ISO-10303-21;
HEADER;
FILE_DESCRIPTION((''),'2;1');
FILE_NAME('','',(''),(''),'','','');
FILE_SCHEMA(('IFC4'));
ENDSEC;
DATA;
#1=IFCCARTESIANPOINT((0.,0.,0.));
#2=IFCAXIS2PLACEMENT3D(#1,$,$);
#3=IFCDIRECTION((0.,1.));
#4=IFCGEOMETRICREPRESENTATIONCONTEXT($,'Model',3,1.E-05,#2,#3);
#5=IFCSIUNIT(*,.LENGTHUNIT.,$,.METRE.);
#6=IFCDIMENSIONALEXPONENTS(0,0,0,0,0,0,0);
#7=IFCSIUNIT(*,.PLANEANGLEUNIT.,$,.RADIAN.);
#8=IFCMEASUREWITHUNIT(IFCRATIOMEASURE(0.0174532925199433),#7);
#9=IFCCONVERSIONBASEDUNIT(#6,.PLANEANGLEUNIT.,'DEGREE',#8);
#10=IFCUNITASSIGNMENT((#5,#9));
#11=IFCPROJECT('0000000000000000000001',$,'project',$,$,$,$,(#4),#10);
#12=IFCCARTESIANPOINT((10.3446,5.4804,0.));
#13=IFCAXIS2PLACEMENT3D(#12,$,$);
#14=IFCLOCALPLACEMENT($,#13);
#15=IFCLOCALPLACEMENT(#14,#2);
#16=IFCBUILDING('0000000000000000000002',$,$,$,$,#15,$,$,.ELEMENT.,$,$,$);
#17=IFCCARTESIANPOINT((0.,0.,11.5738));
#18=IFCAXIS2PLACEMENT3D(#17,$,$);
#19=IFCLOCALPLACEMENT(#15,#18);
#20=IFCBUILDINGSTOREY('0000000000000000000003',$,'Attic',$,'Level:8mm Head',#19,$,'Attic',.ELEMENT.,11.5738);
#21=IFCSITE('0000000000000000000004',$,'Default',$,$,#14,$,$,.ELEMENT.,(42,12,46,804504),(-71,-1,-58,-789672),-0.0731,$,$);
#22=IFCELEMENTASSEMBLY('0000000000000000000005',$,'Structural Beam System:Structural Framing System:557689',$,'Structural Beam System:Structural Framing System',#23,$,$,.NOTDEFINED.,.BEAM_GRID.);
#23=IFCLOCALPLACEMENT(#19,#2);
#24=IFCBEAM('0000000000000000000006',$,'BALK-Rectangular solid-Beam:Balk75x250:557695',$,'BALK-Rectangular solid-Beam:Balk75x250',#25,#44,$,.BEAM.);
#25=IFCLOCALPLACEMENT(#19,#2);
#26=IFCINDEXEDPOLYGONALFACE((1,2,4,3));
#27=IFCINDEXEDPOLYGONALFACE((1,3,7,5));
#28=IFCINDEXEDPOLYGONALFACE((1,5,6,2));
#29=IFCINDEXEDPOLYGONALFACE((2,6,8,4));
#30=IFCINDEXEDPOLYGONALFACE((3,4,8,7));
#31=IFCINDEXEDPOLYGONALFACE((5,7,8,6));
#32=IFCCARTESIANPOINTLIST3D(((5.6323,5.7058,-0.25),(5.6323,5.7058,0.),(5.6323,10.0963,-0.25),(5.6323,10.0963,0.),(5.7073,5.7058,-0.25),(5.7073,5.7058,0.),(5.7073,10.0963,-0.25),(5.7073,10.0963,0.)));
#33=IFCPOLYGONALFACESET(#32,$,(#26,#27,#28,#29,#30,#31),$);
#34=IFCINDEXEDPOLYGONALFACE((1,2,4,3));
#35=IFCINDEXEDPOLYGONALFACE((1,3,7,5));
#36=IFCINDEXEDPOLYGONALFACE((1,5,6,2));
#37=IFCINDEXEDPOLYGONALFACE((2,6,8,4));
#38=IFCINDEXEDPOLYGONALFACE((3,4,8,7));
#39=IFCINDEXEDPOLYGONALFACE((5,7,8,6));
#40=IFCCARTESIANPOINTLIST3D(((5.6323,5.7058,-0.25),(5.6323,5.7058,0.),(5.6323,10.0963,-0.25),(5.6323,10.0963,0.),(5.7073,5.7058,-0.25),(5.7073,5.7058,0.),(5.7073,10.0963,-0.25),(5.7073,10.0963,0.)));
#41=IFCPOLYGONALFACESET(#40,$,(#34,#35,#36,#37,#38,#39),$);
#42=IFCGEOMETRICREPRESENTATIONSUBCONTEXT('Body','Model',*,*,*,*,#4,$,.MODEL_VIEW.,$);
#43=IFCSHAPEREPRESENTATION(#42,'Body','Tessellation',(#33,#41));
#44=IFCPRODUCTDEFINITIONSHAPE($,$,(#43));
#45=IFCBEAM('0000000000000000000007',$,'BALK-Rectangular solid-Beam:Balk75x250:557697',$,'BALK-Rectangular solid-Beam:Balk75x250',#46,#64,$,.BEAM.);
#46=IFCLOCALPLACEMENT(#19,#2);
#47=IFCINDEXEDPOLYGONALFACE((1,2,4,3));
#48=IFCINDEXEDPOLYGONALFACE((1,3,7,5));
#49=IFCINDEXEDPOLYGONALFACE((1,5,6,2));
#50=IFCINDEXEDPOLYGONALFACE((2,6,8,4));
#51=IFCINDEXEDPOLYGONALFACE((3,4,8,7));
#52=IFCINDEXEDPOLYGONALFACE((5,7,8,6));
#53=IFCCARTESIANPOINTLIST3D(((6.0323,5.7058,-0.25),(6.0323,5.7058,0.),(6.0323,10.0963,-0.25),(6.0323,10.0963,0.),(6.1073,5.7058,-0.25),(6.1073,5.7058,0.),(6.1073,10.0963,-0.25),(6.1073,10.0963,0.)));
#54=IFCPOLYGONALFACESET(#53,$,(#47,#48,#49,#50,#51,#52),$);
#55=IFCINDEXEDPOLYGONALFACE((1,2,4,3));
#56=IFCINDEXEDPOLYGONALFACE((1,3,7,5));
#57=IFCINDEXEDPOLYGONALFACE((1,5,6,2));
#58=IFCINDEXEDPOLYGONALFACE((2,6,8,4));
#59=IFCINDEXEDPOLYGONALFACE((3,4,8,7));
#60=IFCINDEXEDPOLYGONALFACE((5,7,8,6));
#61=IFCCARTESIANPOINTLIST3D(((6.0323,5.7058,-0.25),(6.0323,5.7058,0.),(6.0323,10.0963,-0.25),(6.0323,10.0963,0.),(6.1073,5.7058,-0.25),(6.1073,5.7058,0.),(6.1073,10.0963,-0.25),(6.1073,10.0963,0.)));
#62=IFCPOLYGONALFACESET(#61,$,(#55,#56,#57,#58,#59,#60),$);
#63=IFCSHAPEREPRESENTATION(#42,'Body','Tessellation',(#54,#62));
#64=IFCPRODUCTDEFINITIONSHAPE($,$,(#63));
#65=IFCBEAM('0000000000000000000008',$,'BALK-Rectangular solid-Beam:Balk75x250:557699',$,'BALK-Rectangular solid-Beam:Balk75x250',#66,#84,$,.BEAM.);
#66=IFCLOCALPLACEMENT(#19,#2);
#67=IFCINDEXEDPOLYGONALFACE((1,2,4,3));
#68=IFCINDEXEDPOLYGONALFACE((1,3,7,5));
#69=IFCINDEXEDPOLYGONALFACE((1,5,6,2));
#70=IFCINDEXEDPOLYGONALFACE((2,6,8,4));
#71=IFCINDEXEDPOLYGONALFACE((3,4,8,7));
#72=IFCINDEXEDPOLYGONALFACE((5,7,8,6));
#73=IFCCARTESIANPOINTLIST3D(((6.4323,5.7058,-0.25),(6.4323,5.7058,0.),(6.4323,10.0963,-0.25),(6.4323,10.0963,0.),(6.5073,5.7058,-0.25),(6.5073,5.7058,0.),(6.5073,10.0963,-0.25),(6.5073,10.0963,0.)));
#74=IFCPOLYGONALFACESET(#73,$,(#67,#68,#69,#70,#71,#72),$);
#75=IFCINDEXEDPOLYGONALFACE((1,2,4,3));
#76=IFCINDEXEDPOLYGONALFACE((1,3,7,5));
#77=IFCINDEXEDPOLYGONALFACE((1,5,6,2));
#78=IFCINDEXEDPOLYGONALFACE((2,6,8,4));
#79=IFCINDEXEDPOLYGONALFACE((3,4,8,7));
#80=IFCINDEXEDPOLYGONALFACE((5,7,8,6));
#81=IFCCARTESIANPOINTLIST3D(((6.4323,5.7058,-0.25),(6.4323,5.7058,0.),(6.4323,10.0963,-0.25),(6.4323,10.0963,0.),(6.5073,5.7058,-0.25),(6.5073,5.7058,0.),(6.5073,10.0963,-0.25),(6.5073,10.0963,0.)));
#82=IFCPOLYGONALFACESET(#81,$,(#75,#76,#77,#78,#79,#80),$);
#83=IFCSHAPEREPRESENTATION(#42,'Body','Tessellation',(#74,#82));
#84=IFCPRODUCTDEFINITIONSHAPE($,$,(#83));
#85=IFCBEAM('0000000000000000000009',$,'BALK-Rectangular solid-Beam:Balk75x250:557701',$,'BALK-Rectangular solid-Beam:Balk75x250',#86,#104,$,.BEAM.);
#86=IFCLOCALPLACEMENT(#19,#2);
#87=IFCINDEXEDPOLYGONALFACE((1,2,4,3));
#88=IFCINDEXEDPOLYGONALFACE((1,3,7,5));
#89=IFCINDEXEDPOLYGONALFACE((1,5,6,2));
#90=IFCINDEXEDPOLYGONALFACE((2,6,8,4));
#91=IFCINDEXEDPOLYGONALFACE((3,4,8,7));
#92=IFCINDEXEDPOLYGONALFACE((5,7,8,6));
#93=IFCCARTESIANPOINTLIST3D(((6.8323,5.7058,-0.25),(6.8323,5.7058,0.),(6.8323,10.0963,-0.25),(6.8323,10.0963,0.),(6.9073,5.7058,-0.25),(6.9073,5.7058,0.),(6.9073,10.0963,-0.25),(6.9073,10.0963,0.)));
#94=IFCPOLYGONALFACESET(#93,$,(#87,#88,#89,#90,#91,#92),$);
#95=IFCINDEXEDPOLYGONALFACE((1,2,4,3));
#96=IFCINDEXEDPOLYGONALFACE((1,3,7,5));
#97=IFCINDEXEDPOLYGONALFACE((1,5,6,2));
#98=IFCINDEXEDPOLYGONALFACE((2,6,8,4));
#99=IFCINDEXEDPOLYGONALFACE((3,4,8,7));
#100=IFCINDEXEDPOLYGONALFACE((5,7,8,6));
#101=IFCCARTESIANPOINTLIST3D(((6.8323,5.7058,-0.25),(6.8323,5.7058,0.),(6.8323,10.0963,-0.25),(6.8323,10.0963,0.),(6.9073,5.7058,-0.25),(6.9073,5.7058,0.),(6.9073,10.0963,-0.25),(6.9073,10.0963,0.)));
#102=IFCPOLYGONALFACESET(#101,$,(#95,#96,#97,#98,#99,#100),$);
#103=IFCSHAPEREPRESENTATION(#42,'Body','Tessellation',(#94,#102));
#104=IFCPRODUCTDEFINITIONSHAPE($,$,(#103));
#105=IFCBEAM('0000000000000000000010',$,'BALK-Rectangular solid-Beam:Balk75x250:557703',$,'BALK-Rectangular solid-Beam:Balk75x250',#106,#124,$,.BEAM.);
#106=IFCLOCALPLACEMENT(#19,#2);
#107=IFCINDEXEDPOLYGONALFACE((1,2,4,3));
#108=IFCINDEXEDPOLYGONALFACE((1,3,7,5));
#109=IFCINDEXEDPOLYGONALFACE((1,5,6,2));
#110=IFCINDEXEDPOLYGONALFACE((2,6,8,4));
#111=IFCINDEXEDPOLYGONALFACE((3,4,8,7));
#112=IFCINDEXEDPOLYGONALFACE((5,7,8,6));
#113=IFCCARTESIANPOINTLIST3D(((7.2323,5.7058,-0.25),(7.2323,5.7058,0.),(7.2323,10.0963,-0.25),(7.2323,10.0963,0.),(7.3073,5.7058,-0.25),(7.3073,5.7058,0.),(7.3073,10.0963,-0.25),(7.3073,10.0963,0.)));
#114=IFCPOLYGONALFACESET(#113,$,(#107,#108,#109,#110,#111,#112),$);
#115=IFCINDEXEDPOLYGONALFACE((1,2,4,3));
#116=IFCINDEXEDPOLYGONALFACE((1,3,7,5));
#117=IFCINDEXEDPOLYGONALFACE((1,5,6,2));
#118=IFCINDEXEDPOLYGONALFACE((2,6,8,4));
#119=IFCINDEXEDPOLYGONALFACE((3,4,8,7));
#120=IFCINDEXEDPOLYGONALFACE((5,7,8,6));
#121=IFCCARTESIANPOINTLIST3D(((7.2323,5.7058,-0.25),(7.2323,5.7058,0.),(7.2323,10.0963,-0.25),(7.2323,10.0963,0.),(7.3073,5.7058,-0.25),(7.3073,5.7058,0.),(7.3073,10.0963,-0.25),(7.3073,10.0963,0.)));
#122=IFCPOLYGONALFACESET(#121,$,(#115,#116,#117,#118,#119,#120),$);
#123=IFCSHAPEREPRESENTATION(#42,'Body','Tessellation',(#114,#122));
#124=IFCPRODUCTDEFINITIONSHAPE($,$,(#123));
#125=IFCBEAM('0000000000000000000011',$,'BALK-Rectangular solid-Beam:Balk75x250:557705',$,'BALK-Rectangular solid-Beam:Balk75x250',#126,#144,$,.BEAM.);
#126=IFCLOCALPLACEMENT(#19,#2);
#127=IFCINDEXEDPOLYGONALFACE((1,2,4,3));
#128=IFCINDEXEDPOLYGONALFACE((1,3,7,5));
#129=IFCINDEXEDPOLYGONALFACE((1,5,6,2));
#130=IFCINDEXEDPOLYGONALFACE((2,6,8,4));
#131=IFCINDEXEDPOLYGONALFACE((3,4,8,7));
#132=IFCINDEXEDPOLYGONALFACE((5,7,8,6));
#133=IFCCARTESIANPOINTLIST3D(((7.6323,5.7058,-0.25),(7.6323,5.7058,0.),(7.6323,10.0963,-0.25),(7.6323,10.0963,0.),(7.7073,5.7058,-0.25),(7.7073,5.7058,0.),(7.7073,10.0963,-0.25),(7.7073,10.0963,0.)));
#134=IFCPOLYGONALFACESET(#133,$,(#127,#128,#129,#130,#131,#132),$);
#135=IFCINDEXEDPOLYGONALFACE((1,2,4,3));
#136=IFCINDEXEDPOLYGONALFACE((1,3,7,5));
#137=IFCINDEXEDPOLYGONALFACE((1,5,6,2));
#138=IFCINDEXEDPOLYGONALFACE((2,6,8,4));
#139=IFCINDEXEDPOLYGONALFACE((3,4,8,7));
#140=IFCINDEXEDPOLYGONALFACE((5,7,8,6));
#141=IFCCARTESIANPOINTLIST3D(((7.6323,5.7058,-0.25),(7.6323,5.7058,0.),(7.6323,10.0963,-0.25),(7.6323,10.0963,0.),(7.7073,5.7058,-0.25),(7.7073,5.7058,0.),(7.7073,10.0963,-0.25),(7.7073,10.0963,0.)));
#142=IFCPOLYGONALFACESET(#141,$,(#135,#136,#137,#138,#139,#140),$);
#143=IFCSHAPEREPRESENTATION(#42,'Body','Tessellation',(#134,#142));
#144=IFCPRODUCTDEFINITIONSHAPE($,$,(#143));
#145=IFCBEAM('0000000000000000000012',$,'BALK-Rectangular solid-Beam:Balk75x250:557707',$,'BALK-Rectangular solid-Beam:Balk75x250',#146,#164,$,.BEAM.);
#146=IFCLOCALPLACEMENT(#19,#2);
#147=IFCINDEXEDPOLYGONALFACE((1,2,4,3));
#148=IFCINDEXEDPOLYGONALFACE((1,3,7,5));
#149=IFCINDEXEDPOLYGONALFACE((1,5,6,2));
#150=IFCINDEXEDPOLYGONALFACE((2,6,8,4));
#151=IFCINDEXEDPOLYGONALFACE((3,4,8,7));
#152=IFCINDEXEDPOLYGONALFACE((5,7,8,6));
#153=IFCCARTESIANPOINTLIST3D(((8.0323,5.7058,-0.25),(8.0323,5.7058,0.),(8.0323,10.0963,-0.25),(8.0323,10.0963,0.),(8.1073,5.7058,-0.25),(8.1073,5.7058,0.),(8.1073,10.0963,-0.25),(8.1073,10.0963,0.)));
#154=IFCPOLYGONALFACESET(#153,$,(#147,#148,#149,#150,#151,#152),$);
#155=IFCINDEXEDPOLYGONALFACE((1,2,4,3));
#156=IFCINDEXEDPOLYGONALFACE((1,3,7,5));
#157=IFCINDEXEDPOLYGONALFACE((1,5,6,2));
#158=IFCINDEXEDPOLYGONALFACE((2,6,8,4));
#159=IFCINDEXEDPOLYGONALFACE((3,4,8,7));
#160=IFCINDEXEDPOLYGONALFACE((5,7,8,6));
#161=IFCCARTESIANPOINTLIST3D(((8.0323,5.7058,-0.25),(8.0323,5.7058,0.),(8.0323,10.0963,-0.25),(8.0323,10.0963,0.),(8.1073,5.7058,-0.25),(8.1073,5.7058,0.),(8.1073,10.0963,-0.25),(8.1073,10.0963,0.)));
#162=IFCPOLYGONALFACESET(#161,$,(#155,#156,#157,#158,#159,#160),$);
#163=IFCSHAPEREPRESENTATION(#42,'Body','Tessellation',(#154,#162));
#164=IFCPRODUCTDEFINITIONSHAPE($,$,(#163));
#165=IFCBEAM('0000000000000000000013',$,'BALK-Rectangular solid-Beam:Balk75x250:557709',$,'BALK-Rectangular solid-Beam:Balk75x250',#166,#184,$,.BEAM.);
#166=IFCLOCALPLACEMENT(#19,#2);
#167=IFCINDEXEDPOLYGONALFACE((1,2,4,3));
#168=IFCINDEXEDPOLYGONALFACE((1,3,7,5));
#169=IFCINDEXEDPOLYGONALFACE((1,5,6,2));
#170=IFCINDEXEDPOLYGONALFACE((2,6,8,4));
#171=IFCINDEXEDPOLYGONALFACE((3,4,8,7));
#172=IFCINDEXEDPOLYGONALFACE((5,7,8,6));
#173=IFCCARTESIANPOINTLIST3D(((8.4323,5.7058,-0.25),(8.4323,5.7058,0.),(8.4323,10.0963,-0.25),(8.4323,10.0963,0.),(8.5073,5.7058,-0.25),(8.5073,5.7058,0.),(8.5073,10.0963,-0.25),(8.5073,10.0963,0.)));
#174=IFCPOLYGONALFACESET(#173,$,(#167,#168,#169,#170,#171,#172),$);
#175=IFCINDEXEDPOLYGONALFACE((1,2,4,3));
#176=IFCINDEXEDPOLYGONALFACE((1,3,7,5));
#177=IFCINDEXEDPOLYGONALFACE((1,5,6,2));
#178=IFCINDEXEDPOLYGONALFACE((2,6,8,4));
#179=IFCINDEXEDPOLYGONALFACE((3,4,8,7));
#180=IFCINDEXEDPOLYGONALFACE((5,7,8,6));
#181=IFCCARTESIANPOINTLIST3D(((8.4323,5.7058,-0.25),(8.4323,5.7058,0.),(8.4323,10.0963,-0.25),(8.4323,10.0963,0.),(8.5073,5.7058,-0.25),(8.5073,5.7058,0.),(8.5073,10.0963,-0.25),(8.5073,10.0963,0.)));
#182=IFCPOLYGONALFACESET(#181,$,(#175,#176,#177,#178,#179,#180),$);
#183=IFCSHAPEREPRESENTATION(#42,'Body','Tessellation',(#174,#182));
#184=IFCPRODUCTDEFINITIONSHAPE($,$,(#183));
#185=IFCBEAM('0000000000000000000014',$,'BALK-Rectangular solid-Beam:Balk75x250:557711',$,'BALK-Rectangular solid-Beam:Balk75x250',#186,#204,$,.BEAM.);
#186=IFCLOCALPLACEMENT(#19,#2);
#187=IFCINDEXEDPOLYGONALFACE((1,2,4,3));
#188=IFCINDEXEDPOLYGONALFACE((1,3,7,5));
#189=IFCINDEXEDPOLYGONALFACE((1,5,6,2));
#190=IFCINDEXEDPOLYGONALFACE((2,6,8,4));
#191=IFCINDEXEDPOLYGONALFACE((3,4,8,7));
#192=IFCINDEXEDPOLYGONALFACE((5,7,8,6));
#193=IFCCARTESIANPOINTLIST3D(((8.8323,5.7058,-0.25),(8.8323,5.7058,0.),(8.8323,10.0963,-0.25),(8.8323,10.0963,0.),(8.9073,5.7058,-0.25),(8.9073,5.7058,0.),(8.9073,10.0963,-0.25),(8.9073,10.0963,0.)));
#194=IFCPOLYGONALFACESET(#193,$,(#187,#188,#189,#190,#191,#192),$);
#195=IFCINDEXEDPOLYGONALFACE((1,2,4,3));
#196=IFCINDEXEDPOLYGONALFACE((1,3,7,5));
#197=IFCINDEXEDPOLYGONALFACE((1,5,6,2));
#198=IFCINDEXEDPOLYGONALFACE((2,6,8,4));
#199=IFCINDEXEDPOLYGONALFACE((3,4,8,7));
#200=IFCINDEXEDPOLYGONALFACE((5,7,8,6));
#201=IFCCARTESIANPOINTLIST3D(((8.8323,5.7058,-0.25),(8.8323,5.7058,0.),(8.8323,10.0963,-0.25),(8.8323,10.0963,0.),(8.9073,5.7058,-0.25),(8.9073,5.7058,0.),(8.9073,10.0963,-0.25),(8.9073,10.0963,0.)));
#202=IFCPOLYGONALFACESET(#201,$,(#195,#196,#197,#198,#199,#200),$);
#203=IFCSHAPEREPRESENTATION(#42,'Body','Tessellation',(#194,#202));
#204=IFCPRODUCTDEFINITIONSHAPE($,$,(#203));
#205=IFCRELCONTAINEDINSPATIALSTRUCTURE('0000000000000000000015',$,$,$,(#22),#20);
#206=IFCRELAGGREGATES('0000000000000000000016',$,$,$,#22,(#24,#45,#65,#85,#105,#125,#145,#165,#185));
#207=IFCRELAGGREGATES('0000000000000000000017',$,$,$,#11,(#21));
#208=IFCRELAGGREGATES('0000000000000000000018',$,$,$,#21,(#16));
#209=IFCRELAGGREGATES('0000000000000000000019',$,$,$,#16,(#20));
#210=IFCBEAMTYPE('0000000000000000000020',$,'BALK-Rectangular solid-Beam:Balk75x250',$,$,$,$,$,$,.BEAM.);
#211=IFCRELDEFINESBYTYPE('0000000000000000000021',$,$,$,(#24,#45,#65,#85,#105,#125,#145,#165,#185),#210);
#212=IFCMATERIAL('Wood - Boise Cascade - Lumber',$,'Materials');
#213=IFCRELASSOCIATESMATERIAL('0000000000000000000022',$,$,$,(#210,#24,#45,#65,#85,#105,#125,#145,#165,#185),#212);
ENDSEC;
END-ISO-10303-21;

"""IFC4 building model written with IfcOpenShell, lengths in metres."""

from ifc_helpers import new_model, entity, si_unit, converted_unit, direction, frame, frame_2d, origin, origin_2d_with_axis, place, context, subcontext, project, spatial, rectangle, extrude, source, transform, mapped, material, material_profile, profile_set, profile_usage, type_object, type_shapes, element, aggregate, save


model = new_model("IFC4")

# Units and contexts
model_context = context("Model", 3, precision=1e-05, world=origin(), true_north=direction((0.0, 1.0)))
body_context = subcontext(model_context, "Body", "Model", "MODEL_VIEW")
ifc_project = project(units=[si_unit("LENGTHUNIT", "METRE"), converted_unit("PLANEANGLEUNIT", "DEGREE", entity("IfcRatioMeasure", 0.0174532925199433), si_unit("PLANEANGLEUNIT", "RADIAN"), dimensions=[0, 0, 0, 0, 0, 0, 0])], contexts=[model_context])

# Site, building, storey
site_placement = place(None, frame((10.3446, 5.4804, 0.0)))
site = spatial("IfcSite", under=ifc_project, at=site_placement, Name="Default", CompositionType="ELEMENT", RefLatitude=(42, 12, 46, 804504), RefLongitude=(-71, -1, -58, -789672), RefElevation=-0.0731)
building_placement = place(site_placement, origin())
building = spatial("IfcBuilding", under=site, at=building_placement, CompositionType="ELEMENT")
storey_placement = place(building_placement, frame((0.0, 0.0, 11.5738)))
storey = spatial("IfcBuildingStorey", under=building, at=storey_placement, Name="Attic", ObjectType="Level:8mm Head", LongName="Attic", CompositionType="ELEMENT", Elevation=11.5738)

# Element assembly, beams
assembly_1_placement = place(storey_placement, origin())
assembly_1 = element("IfcElementAssembly", 1, at=assembly_1_placement, inside=storey, Name="Structural Beam System:Structural Framing System:557689", ObjectType="Structural Beam System:Structural Framing System", AssemblyPlace="NOTDEFINED", PredefinedType="BEAM_GRID")
ifc_material = material(Name="Wood - Boise Cascade - Lumber", Category="Materials")
ifc_material_profile = material_profile(ifc_material, rectangle(XDim=0.25, YDim=0.075, at=frame_2d((0.0, 0.0), x_axis=(1.0, 0.0))), Name="Balk75x250")
ifc_profile_set = profile_set([ifc_material_profile], Name="Balk75x250")
ifc_profile_usage_1 = profile_usage(ifc_profile_set, cardinal=8)
beam_type_1 = type_object("IfcBeamType", Name="BALK-Rectangular solid-Beam:Balk75x250", PredefinedType="BEAM", material=ifc_profile_set)
shared_shape_1 = source(origin(), body_context, "Body", "SweptSolid", [
    extrude(rectangle(XDim=0.25, YDim=0.075, at=origin_2d_with_axis()), frame((-2.3015, 0.0, 0.0), z_axis=(1.0, 0.0, 0.0), x_axis=(0.0, 0.0, -1.0)), (0.0, 0.0, 1.0), 4.3905),
    extrude(rectangle(XDim=0.25, YDim=0.075, at=origin_2d_with_axis()), frame((-2.3015, 0.0, 0.0), z_axis=(1.0, 0.0, 0.0), x_axis=(0.0, 0.0, -1.0)), (0.0, 0.0, 1.0), 4.3905),
])
type_shapes(beam_type_1, [shared_shape_1])
beam_1_placement = place(assembly_1_placement, frame((5.6698, 8.0073, -0.125), z_axis=(0.0, 0.0, 1.0), x_axis=(0.0, 1.0, 0.0)))
beam_1 = element("IfcBeam", 2, at=beam_1_placement, type_object=beam_type_1, material=ifc_profile_usage_1, Name="BALK-Rectangular solid-Beam:Balk75x250:557695", ObjectType="BALK-Rectangular solid-Beam:Balk75x250", PredefinedType="BEAM", context=body_context, shape_type="MappedRepresentation", body=[
    mapped(shared_shape_1, transform((0.0, 0.0, 0.0), scale=1.0)),
])
ifc_profile_usage_2 = profile_usage(ifc_profile_set, cardinal=8)
beam_2_placement = place(assembly_1_placement, frame((6.0698, 8.0073, -0.125), z_axis=(0.0, 0.0, 1.0), x_axis=(0.0, 1.0, 0.0)))
beam_2 = element("IfcBeam", 3, at=beam_2_placement, type_object=beam_type_1, material=ifc_profile_usage_2, Name="BALK-Rectangular solid-Beam:Balk75x250:557697", ObjectType="BALK-Rectangular solid-Beam:Balk75x250", PredefinedType="BEAM", context=body_context, shape_type="MappedRepresentation", body=[
    mapped(shared_shape_1, transform((0.0, 0.0, 0.0), scale=1.0)),
])
ifc_profile_usage_3 = profile_usage(ifc_profile_set, cardinal=8)
beam_3_placement = place(assembly_1_placement, frame((6.4698, 8.0073, -0.125), z_axis=(0.0, 0.0, 1.0), x_axis=(0.0, 1.0, 0.0)))
beam_3 = element("IfcBeam", 4, at=beam_3_placement, type_object=beam_type_1, material=ifc_profile_usage_3, Name="BALK-Rectangular solid-Beam:Balk75x250:557699", ObjectType="BALK-Rectangular solid-Beam:Balk75x250", PredefinedType="BEAM", context=body_context, shape_type="MappedRepresentation", body=[
    mapped(shared_shape_1, transform((0.0, 0.0, 0.0), scale=1.0)),
])
ifc_profile_usage_4 = profile_usage(ifc_profile_set, cardinal=8)
beam_4_placement = place(assembly_1_placement, frame((6.8698, 8.0073, -0.125), z_axis=(0.0, 0.0, 1.0), x_axis=(0.0, 1.0, 0.0)))
beam_4 = element("IfcBeam", 5, at=beam_4_placement, type_object=beam_type_1, material=ifc_profile_usage_4, Name="BALK-Rectangular solid-Beam:Balk75x250:557701", ObjectType="BALK-Rectangular solid-Beam:Balk75x250", PredefinedType="BEAM", context=body_context, shape_type="MappedRepresentation", body=[
    mapped(shared_shape_1, transform((0.0, 0.0, 0.0), scale=1.0)),
])
ifc_profile_usage_5 = profile_usage(ifc_profile_set, cardinal=8)
beam_5_placement = place(assembly_1_placement, frame((7.2698, 8.0073, -0.125), z_axis=(0.0, 0.0, 1.0), x_axis=(0.0, 1.0, 0.0)))
beam_5 = element("IfcBeam", 6, at=beam_5_placement, type_object=beam_type_1, material=ifc_profile_usage_5, Name="BALK-Rectangular solid-Beam:Balk75x250:557703", ObjectType="BALK-Rectangular solid-Beam:Balk75x250", PredefinedType="BEAM", context=body_context, shape_type="MappedRepresentation", body=[
    mapped(shared_shape_1, transform((0.0, 0.0, 0.0), scale=1.0)),
])
ifc_profile_usage_6 = profile_usage(ifc_profile_set, cardinal=8)
beam_6_placement = place(assembly_1_placement, frame((7.6698, 8.0073, -0.125), z_axis=(0.0, 0.0, 1.0), x_axis=(0.0, 1.0, 0.0)))
beam_6 = element("IfcBeam", 7, at=beam_6_placement, type_object=beam_type_1, material=ifc_profile_usage_6, Name="BALK-Rectangular solid-Beam:Balk75x250:557705", ObjectType="BALK-Rectangular solid-Beam:Balk75x250", PredefinedType="BEAM", context=body_context, shape_type="MappedRepresentation", body=[
    mapped(shared_shape_1, transform((0.0, 0.0, 0.0), scale=1.0)),
])
ifc_profile_usage_7 = profile_usage(ifc_profile_set, cardinal=8)
beam_7_placement = place(assembly_1_placement, frame((8.0698, 8.0073, -0.125), z_axis=(0.0, 0.0, 1.0), x_axis=(0.0, 1.0, 0.0)))
beam_7 = element("IfcBeam", 8, at=beam_7_placement, type_object=beam_type_1, material=ifc_profile_usage_7, Name="BALK-Rectangular solid-Beam:Balk75x250:557707", ObjectType="BALK-Rectangular solid-Beam:Balk75x250", PredefinedType="BEAM", context=body_context, shape_type="MappedRepresentation", body=[
    mapped(shared_shape_1, transform((0.0, 0.0, 0.0), scale=1.0)),
])
ifc_profile_usage_8 = profile_usage(ifc_profile_set, cardinal=8)
beam_8_placement = place(assembly_1_placement, frame((8.4698, 8.0073, -0.125), z_axis=(0.0, 0.0, 1.0), x_axis=(0.0, 1.0, 0.0)))
beam_8 = element("IfcBeam", 9, at=beam_8_placement, type_object=beam_type_1, material=ifc_profile_usage_8, Name="BALK-Rectangular solid-Beam:Balk75x250:557709", ObjectType="BALK-Rectangular solid-Beam:Balk75x250", PredefinedType="BEAM", context=body_context, shape_type="MappedRepresentation", body=[
    mapped(shared_shape_1, transform((0.0, 0.0, 0.0), scale=1.0)),
])
ifc_profile_usage_9 = profile_usage(ifc_profile_set, cardinal=8)
beam_9_placement = place(assembly_1_placement, frame((8.8698, 8.0073, -0.125), z_axis=(0.0, 0.0, 1.0), x_axis=(0.0, 1.0, 0.0)))
beam_9 = element("IfcBeam", 10, at=beam_9_placement, type_object=beam_type_1, material=ifc_profile_usage_9, Name="BALK-Rectangular solid-Beam:Balk75x250:557711", ObjectType="BALK-Rectangular solid-Beam:Balk75x250", PredefinedType="BEAM", context=body_context, shape_type="MappedRepresentation", body=[
    mapped(shared_shape_1, transform((0.0, 0.0, 0.0), scale=1.0)),
])
aggregate(assembly_1, [beam_1, beam_2, beam_3, beam_4, beam_5, beam_6, beam_7, beam_8, beam_9])

save(model, "model.ifc")
